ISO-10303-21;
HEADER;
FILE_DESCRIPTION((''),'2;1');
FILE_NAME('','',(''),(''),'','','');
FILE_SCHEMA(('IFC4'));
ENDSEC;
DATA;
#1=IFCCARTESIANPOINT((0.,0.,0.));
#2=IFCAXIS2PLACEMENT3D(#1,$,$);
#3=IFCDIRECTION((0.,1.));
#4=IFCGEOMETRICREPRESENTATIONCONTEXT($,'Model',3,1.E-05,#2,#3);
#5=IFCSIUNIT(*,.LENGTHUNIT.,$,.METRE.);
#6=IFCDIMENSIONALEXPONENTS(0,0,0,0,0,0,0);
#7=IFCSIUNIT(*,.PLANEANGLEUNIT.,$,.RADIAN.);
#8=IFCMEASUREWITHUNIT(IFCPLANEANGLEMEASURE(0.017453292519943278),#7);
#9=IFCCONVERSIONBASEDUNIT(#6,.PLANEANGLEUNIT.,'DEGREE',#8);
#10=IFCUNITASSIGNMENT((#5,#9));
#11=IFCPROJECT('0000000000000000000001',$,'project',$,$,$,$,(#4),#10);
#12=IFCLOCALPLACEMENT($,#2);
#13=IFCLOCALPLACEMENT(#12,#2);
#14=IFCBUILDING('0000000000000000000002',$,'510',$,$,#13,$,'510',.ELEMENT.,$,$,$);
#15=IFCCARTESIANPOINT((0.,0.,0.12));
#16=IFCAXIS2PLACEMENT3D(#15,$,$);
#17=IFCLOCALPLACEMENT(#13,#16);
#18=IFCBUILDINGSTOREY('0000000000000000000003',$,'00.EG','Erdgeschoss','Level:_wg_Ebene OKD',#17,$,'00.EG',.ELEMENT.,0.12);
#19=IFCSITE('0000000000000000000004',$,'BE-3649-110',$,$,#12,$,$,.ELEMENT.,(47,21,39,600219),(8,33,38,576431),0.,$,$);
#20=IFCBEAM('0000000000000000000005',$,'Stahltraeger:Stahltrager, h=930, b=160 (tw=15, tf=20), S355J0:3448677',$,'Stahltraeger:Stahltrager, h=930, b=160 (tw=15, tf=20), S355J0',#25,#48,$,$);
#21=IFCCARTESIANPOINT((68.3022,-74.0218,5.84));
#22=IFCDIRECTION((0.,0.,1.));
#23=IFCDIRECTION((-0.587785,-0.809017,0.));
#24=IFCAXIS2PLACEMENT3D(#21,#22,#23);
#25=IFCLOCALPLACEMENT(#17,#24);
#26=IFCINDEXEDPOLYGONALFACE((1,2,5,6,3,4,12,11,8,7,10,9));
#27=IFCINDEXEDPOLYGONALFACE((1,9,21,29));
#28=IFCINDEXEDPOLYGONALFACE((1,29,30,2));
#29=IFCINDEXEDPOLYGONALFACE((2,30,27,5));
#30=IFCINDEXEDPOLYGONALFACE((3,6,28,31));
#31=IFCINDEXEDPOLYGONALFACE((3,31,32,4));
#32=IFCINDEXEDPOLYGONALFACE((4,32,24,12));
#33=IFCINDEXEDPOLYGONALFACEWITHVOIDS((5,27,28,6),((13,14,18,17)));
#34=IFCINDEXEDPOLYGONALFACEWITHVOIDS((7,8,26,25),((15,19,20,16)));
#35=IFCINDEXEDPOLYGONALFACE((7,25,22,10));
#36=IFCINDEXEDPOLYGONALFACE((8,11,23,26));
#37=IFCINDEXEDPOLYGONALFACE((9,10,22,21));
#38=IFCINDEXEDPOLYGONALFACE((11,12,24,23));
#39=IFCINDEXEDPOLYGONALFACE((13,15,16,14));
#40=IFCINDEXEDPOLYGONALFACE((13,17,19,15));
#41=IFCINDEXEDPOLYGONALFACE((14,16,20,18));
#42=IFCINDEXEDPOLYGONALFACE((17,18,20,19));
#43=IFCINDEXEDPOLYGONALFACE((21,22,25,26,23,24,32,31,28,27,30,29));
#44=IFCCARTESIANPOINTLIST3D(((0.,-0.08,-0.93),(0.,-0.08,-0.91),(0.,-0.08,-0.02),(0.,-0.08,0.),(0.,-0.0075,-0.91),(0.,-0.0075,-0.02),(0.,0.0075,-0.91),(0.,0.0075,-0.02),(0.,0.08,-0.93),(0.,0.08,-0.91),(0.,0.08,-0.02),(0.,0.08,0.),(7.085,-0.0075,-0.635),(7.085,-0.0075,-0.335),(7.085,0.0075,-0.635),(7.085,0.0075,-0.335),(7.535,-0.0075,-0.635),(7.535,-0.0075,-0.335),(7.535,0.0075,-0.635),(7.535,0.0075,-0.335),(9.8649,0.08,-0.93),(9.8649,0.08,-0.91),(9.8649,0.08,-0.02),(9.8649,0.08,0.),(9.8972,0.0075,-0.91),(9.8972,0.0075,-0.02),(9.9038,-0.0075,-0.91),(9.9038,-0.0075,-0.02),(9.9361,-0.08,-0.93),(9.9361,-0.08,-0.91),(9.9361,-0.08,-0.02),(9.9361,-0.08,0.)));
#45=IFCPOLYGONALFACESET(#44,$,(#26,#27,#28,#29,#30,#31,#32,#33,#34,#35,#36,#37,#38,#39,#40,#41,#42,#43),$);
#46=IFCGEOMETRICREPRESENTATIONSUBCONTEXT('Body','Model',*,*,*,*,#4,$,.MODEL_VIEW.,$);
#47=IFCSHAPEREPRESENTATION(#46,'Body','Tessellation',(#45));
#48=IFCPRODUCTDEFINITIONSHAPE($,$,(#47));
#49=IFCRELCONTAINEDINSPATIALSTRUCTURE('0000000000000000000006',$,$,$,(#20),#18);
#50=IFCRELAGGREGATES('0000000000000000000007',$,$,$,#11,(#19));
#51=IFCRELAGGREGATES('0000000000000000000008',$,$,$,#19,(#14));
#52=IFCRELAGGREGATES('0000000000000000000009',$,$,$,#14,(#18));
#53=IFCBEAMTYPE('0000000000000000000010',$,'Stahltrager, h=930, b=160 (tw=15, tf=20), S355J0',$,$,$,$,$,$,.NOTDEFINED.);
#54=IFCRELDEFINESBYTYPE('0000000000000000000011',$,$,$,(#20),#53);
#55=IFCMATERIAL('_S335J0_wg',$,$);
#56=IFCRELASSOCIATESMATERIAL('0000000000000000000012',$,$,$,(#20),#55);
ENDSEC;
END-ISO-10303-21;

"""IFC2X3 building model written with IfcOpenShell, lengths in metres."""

from ifc_helpers import new_model, entity, si_unit, converted_unit, direction, frame, frame_2d, origin, place, context, subcontext, project, spatial, rectangle, i_section, extrude, boolean, clip, halfspace, material, type_object, element, save


model = new_model("IFC2X3")

# Units and contexts
model_context = context("Model", 3, precision=1e-05, world=origin(), true_north=direction((0.0, 1.0)))
body_context = subcontext(model_context, "Body", "Model", "MODEL_VIEW")
ifc_project = project(units=[si_unit("LENGTHUNIT", "METRE"), converted_unit("PLANEANGLEUNIT", "DEGREE", entity("IfcPlaneAngleMeasure", 0.017453292519943278), si_unit("PLANEANGLEUNIT", "RADIAN"), dimensions=[0, 0, 0, 0, 0, 0, 0])], contexts=[model_context])

# Site, building, storey
site_placement = place(None, origin())
site = spatial("IfcSite", under=ifc_project, at=site_placement, Name="BE-3649-110", CompositionType="ELEMENT", RefLatitude=(47, 21, 39, 600219), RefLongitude=(8, 33, 38, 576431), RefElevation=0.0)
building_placement = place(site_placement, origin())
building = spatial("IfcBuilding", under=site, at=building_placement, Name="510", LongName="510", CompositionType="ELEMENT")
storey_placement = place(building_placement, frame((0.0, 0.0, 0.12)))
storey = spatial("IfcBuildingStorey", under=building, at=storey_placement, Name="00.EG", Description="Erdgeschoss", ObjectType="Level:_wg_Ebene OKD", LongName="00.EG", CompositionType="ELEMENT", Elevation=0.12)

# Beam
ifc_material_1 = material(Name="_S335J0_wg")
beam_type_1 = type_object("IfcBeamType", Name="Stahltrager, h=930, b=160 (tw=15, tf=20), S355J0", PredefinedType="NOTDEFINED")
beam_1_placement = place(storey_placement, frame((68.3022, -74.0218, 5.84), z_axis=(0.0, 0.0, 1.0), x_axis=(-0.587785, -0.809017, 0.0)))
element("IfcBeam", 1, at=beam_1_placement, inside=storey, type_object=beam_type_1, material=ifc_material_1, Name="Stahltraeger:Stahltrager, h=930, b=160 (tw=15, tf=20), S355J0:3448677", ObjectType="Stahltraeger:Stahltrager, h=930, b=160 (tw=15, tf=20), S355J0", context=body_context, shape_type="SweptSolid", body=[
    boolean("DIFFERENCE", clip(extrude(i_section(OverallWidth=0.16, OverallDepth=0.93, WebThickness=0.015, FlangeThickness=0.02, at=frame_2d((0.0, 0.0), x_axis=(0.0, 1.0))), frame((0.0, 0.0, -0.465), z_axis=(1.0, 0.0, 0.0), x_axis=(0.0, 0.0, -1.0)), (0.0, 0.0, 1.0), 9.9361), halfspace(frame((9.6886, 0.4759, -6.18), z_axis=(0.913545, 0.406737, 0.0), x_axis=(0.406737, -0.913545, 0.0)), False)), extrude(rectangle(XDim=0.3, YDim=0.45, at=frame_2d((0.0, 0.0), x_axis=(0.0, 1.0))), frame((7.31, 0.0075, -0.485), z_axis=(0.0, -1.0, 0.0), x_axis=(-1.0, 0.0, 0.0)), (0.0, 0.0, 1.0), 0.015)),
])

save(model, "model.ifc")
